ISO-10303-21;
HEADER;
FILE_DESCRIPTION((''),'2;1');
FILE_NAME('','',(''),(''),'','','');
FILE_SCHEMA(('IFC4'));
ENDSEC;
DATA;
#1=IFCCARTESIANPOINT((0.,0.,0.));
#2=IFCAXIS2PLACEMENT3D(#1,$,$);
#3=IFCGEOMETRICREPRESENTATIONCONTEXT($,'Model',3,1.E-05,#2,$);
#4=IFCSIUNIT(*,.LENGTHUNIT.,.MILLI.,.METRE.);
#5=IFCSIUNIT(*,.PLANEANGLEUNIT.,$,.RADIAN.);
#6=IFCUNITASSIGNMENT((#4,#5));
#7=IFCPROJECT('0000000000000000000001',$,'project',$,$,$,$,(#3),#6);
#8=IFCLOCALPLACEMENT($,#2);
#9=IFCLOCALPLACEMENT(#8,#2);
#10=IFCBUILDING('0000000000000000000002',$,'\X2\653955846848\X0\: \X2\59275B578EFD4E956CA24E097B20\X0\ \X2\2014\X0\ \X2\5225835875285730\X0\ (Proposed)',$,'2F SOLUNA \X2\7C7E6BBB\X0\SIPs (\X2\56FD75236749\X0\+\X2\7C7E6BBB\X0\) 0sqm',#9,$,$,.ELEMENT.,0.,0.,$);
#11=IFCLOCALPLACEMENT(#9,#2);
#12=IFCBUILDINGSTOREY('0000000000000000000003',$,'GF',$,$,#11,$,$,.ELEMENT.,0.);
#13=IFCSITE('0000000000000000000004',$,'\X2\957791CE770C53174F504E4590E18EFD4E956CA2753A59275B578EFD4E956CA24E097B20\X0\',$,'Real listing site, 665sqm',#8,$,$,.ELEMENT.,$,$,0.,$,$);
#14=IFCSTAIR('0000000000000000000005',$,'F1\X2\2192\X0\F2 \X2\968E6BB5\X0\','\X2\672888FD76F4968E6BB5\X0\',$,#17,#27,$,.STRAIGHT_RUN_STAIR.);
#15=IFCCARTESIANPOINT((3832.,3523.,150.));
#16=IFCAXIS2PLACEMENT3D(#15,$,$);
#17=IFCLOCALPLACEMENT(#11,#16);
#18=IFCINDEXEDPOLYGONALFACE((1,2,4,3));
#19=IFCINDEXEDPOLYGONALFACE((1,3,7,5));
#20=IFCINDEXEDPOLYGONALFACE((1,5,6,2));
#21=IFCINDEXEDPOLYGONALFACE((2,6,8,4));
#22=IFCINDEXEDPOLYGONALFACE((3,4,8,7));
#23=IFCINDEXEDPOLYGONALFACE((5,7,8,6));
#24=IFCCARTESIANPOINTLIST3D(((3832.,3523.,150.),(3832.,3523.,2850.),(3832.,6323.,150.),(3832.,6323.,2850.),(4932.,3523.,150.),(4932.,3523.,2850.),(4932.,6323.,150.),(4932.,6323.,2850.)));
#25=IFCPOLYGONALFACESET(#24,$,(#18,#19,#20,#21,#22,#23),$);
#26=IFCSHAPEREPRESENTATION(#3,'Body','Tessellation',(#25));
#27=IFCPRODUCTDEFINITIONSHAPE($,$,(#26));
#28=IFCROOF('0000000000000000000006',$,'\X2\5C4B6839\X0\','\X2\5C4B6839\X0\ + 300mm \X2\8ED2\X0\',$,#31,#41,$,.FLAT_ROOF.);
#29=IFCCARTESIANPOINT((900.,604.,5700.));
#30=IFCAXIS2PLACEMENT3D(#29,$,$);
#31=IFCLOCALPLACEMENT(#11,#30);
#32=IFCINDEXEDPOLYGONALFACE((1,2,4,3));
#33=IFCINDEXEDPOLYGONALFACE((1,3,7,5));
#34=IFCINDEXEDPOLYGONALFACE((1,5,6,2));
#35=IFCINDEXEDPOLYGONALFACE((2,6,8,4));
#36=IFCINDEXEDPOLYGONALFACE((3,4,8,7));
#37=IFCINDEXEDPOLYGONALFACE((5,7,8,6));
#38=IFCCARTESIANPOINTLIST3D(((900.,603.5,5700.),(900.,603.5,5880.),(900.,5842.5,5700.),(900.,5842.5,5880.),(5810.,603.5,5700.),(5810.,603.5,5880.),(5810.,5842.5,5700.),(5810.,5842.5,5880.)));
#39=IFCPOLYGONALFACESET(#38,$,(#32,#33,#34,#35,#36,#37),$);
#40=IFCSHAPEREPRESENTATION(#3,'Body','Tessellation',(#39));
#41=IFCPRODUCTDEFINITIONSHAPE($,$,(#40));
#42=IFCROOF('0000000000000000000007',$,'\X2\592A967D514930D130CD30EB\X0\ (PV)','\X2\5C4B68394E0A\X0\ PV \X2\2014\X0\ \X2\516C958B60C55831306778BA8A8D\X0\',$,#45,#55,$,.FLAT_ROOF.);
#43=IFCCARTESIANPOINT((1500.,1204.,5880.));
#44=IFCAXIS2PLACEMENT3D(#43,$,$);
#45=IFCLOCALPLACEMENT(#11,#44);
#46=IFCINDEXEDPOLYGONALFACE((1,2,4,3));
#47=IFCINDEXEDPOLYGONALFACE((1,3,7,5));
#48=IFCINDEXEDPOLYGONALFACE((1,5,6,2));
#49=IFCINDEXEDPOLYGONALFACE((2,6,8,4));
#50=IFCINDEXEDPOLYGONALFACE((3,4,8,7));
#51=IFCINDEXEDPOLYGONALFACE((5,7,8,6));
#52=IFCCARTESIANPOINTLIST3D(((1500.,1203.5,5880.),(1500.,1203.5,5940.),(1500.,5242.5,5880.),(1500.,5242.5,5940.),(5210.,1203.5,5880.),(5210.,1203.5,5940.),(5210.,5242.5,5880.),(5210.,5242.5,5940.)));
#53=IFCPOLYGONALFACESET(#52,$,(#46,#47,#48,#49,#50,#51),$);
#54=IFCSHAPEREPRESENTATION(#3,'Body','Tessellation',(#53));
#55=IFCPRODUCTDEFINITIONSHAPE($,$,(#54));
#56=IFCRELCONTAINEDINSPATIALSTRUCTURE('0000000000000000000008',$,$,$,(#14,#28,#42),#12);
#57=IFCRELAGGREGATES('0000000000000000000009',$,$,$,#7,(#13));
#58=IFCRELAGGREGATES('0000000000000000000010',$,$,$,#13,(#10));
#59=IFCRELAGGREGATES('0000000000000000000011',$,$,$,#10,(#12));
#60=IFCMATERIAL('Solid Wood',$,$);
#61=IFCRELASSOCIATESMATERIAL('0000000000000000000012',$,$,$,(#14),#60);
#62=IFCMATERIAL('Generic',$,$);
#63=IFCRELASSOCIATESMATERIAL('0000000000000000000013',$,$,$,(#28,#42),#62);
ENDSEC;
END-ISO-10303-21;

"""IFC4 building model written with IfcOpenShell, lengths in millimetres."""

from ifc_helpers import new_model, si_unit, frame, frame_2d, origin, place, context, project, spatial, rectangle, extrude, material, element, save


model = new_model("IFC4")

# Units and contexts
model_context = context("Model", 3, precision=1e-05, world=origin())
ifc_project = project(units=[si_unit("LENGTHUNIT", "METRE", prefix="MILLI"), si_unit("PLANEANGLEUNIT", "RADIAN")], contexts=[model_context])

# Site, building, storey
site_placement = place(None, origin())
site = spatial("IfcSite", under=ifc_project, at=site_placement, Name="長野県北佐久郡軽井沢町大字軽井沢三笠", ObjectType="Real listing site, 665sqm", CompositionType="ELEMENT", RefElevation=0.0)
building_placement = place(site_placement, origin())
building = spatial("IfcBuilding", under=site, at=building_placement, Name="改善案: 大字軽井沢三笠 — 別荘用地 (Proposed)", ObjectType="2F SOLUNA 籾殻SIPs (国産杉+籾殻) 0sqm", CompositionType="ELEMENT", ElevationOfRefHeight=0.0, ElevationOfTerrain=0.0)
storey_placement = place(building_placement, origin())
storey = spatial("IfcBuildingStorey", under=building, at=storey_placement, Name="GF", CompositionType="ELEMENT", Elevation=0.0)

# Shared definitions
ifc_material_1 = material(Name="Generic")

# Shared definitions
ifc_material_2 = material(Name="Solid Wood")

# Stair
stair_placement = place(storey_placement, frame((3832.0, 3523.0, 150.0)))
element("IfcStair", 1, at=stair_placement, inside=storey, material=ifc_material_2, Name="F1→F2 階段", Description="木製直階段", PredefinedType="STRAIGHT_RUN_STAIR", context=model_context, shape_type="SweptSolid", body=[
    extrude(rectangle(XDim=1100.0, YDim=2800.0, at=frame_2d((550.0, 1400.0))), frame((3832.0, 3523.0, 150.0)), (0.0, 0.0, 1.0), 2700.0),
])

# Roofs
roof_1_placement = place(storey_placement, frame((900.0, 604.0, 5700.0)))
element("IfcRoof", 2, at=roof_1_placement, inside=storey, material=ifc_material_1, Name="屋根", Description="屋根 + 300mm 軒", PredefinedType="FLAT_ROOF", context=model_context, shape_type="SweptSolid", body=[
    extrude(rectangle(XDim=4910.0, YDim=5239.0, at=frame_2d((2455.0, 2619.0))), frame((900.0, 604.0, 5700.0)), (0.0, 0.0, 1.0), 180.0),
])
roof_2_placement = place(storey_placement, frame((1500.0, 1204.0, 5880.0)))
element("IfcRoof", 3, at=roof_2_placement, inside=storey, material=ifc_material_1, Name="太陽光パネル (PV)", Description="屋根上 PV — 公開情報で確認", PredefinedType="FLAT_ROOF", context=model_context, shape_type="SweptSolid", body=[
    extrude(rectangle(XDim=3710.0, YDim=4039.0, at=frame_2d((1855.0, 2019.0))), frame((1500.0, 1204.0, 5880.0)), (0.0, 0.0, 1.0), 60.0),
])

save(model, "model.ifc")
